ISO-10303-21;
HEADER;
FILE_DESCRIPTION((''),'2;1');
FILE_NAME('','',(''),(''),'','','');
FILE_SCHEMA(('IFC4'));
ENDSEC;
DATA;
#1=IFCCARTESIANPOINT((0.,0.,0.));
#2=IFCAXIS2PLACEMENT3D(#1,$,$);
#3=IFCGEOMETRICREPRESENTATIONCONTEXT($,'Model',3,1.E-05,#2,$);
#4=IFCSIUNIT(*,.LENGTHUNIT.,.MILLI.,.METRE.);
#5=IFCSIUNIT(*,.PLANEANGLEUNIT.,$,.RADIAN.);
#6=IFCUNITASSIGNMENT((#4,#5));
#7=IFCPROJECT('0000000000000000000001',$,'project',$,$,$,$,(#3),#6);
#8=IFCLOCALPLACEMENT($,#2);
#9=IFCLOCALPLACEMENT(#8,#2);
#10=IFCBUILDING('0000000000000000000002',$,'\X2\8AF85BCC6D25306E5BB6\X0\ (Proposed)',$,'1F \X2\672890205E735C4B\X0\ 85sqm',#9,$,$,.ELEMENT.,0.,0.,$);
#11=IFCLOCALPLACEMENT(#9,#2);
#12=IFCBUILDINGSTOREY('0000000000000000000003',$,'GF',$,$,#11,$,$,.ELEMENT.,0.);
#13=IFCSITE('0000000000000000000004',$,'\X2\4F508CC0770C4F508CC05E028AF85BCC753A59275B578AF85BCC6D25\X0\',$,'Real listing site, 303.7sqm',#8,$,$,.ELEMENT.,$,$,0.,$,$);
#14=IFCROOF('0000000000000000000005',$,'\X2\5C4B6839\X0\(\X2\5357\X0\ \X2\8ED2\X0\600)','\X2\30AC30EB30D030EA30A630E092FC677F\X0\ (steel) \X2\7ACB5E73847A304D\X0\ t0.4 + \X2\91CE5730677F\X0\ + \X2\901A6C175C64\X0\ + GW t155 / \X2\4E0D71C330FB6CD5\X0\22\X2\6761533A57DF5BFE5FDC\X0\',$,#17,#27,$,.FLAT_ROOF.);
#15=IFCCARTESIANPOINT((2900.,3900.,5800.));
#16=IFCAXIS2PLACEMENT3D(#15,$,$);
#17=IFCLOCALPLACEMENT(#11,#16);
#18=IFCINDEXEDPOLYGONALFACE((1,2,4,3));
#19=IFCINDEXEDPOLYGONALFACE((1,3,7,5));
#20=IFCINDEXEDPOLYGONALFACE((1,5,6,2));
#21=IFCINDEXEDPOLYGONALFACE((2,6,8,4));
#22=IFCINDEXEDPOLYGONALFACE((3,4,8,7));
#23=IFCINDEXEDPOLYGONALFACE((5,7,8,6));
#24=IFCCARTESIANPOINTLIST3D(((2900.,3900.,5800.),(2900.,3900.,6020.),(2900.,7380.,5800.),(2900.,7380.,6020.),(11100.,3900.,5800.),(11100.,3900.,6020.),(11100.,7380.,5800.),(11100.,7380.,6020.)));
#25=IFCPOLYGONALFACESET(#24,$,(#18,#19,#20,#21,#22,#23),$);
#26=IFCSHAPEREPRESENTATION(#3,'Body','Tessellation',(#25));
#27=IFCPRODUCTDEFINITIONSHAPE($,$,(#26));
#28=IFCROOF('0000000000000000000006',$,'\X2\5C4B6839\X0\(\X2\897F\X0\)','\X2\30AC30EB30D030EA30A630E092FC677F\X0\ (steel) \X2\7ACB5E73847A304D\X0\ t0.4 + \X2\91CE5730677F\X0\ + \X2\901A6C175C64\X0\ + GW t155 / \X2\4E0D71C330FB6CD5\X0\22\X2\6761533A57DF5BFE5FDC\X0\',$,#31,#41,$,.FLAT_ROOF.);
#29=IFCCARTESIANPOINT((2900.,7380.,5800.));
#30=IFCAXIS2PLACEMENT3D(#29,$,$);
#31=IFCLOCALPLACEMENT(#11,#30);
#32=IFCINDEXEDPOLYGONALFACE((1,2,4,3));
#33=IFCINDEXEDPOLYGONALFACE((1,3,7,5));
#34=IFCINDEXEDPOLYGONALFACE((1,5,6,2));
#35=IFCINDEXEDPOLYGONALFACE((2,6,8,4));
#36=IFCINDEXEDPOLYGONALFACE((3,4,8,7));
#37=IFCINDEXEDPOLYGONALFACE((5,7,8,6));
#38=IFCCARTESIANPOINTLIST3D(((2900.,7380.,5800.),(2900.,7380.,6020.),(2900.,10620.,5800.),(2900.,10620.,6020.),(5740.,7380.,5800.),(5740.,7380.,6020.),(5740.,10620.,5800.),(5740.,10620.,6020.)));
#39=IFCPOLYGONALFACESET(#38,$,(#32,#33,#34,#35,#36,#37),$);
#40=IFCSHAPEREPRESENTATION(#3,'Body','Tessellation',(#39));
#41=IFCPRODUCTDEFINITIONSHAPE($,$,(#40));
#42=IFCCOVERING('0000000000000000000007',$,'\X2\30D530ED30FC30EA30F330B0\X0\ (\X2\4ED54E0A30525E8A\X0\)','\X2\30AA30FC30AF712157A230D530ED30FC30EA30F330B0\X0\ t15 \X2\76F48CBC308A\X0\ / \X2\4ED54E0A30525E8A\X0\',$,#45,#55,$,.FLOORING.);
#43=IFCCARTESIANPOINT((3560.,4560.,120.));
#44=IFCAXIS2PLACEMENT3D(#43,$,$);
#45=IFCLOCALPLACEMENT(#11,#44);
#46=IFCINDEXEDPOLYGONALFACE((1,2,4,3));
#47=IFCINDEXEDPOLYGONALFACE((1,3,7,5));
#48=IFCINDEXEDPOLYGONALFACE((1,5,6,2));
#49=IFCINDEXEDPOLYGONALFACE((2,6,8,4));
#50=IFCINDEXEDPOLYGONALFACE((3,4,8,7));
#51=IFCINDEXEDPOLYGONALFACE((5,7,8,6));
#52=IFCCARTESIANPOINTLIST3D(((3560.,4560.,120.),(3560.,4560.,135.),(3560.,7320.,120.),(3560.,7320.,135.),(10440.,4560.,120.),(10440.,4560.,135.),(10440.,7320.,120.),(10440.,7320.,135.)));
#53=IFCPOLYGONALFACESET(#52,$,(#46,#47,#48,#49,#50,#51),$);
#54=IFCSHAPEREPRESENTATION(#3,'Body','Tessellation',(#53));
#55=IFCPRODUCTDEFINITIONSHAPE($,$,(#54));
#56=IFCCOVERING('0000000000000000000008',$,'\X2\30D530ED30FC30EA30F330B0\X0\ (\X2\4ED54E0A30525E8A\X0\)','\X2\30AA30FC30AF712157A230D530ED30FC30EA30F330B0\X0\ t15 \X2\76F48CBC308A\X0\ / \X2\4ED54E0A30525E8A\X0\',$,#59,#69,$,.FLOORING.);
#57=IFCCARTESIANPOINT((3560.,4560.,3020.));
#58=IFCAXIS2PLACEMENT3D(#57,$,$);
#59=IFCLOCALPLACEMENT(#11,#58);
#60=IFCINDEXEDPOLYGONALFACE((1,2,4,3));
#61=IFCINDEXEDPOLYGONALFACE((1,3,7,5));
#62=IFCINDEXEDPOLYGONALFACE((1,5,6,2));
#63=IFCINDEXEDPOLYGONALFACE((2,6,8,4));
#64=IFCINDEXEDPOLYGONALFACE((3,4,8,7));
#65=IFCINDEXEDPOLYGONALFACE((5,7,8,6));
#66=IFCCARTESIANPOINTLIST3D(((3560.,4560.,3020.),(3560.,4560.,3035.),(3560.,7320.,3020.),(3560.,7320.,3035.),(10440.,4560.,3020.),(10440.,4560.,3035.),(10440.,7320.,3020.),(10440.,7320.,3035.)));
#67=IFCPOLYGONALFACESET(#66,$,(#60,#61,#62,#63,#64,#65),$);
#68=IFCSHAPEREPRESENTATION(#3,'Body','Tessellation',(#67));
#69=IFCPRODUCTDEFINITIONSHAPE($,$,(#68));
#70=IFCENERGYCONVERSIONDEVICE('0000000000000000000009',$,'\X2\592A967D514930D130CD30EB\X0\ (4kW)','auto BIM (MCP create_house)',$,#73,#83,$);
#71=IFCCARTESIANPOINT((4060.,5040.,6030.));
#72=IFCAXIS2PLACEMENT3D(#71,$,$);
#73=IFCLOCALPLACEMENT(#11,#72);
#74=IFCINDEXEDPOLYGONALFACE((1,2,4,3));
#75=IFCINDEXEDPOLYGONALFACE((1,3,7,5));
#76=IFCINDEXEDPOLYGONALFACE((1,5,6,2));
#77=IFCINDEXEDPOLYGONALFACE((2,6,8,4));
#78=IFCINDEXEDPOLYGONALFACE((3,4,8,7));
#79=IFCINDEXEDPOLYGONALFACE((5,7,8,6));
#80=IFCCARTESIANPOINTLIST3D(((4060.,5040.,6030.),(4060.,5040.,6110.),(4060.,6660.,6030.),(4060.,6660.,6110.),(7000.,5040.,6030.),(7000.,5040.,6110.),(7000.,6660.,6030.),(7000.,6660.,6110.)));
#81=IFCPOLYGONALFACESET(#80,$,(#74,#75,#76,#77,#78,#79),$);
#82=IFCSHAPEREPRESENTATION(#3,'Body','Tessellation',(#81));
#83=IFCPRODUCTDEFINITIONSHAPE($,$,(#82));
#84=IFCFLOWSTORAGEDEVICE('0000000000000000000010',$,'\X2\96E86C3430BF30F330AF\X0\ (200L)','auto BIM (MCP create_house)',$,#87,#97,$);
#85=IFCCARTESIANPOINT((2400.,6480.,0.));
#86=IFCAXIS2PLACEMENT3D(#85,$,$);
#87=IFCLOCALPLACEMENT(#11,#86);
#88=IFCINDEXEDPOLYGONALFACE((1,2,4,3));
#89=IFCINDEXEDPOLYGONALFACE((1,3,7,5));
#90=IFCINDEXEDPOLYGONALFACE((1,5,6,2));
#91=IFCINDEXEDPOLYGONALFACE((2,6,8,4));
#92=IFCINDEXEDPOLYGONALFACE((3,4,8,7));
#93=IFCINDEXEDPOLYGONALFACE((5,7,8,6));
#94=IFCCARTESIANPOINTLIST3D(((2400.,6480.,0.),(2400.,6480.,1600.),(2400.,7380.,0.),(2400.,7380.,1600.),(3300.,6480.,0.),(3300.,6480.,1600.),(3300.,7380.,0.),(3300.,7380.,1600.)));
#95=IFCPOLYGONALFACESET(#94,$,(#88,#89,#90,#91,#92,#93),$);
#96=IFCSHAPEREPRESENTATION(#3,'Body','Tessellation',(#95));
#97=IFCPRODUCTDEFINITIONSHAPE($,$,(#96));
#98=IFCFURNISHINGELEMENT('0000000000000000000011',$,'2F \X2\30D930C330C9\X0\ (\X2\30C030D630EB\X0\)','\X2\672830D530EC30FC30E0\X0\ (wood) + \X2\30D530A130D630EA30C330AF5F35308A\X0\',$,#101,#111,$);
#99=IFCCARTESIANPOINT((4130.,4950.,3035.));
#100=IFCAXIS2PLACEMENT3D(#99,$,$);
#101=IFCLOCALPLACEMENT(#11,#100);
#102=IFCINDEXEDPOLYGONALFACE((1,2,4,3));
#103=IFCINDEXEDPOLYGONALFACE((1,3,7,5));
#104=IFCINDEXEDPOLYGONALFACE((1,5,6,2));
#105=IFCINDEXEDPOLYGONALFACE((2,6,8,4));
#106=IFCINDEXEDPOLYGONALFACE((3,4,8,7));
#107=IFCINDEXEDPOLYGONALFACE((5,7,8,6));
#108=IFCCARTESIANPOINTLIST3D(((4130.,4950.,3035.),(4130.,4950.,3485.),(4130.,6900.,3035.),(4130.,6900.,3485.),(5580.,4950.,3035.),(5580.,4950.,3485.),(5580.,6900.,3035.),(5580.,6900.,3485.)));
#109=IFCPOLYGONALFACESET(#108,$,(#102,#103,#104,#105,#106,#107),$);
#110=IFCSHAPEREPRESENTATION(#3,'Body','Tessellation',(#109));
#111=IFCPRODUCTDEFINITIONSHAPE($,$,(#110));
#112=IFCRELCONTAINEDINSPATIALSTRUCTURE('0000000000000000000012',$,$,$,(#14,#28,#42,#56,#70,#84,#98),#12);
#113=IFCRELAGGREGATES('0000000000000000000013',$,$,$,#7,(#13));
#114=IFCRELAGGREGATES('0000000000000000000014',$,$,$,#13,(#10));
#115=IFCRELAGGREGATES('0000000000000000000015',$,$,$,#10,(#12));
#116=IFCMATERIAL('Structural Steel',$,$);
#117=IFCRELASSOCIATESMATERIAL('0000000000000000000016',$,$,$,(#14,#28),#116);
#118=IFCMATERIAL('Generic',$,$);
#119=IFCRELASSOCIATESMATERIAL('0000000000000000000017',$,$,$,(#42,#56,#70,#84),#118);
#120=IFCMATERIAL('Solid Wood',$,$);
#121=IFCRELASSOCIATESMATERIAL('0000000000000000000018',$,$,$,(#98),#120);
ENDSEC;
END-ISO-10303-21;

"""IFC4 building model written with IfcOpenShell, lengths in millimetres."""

from ifc_helpers import new_model, si_unit, frame, frame_2d, origin, place, context, project, spatial, rectangle, extrude, material, element, save


model = new_model("IFC4")

# Units and contexts
model_context = context("Model", 3, precision=1e-05, world=origin())
ifc_project = project(units=[si_unit("LENGTHUNIT", "METRE", prefix="MILLI"), si_unit("PLANEANGLEUNIT", "RADIAN")], contexts=[model_context])

# Site, building, storey
site_placement = place(None, origin())
site = spatial("IfcSite", under=ifc_project, at=site_placement, Name="佐賀県佐賀市諸富町大字諸富津", ObjectType="Real listing site, 303.7sqm", CompositionType="ELEMENT", RefElevation=0.0)
building_placement = place(site_placement, origin())
building = spatial("IfcBuilding", under=site, at=building_placement, Name="諸富津の家 (Proposed)", ObjectType="1F 木造平屋 85sqm", CompositionType="ELEMENT", ElevationOfRefHeight=0.0, ElevationOfTerrain=0.0)
storey_placement = place(building_placement, origin())
storey = spatial("IfcBuildingStorey", under=building, at=storey_placement, Name="GF", CompositionType="ELEMENT", Elevation=0.0)

# Shared definitions
ifc_material_1 = material(Name="Solid Wood")
ifc_material_2 = material(Name="Generic")

# Roofs
ifc_material_3 = material(Name="Structural Steel")
roof_1_placement = place(storey_placement, frame((2900.0, 3900.0, 5800.0)))
element("IfcRoof", 1, at=roof_1_placement, inside=storey, material=ifc_material_3, Name="屋根(南 軒600)", Description="ガルバリウム鋼板 (steel) 立平葺き t0.4 + 野地板 + 通気層 + GW t155 / 不燃・法22条区域対応", PredefinedType="FLAT_ROOF", context=model_context, shape_type="SweptSolid", body=[
    extrude(rectangle(XDim=8200.0, YDim=3480.0, at=frame_2d((4100.0, 1740.0))), frame((2900.0, 3900.0, 5800.0)), (0.0, 0.0, 1.0), 220.0),
])
roof_2_placement = place(storey_placement, frame((2900.0, 7380.0, 5800.0)))
element("IfcRoof", 2, at=roof_2_placement, inside=storey, material=ifc_material_3, Name="屋根(西)", Description="ガルバリウム鋼板 (steel) 立平葺き t0.4 + 野地板 + 通気層 + GW t155 / 不燃・法22条区域対応", PredefinedType="FLAT_ROOF", context=model_context, shape_type="SweptSolid", body=[
    extrude(rectangle(XDim=2840.0, YDim=3240.0, at=frame_2d((1420.0, 1620.0))), frame((2900.0, 7380.0, 5800.0)), (0.0, 0.0, 1.0), 220.0),
])

# Coverings
covering_1_placement = place(storey_placement, frame((3560.0, 4560.0, 120.0)))
element("IfcCovering", 3, at=covering_1_placement, inside=storey, material=ifc_material_2, Name="フローリング (仕上げ床)", Description="オーク無垢フローリング t15 直貼り / 仕上げ床", PredefinedType="FLOORING", context=model_context, shape_type="SweptSolid", body=[
    extrude(rectangle(XDim=6880.0, YDim=2760.0, at=frame_2d((3440.0, 1380.0))), frame((3560.0, 4560.0, 120.0)), (0.0, 0.0, 1.0), 15.0),
])
covering_2_placement = place(storey_placement, frame((3560.0, 4560.0, 3020.0)))
element("IfcCovering", 4, at=covering_2_placement, inside=storey, material=ifc_material_2, Name="フローリング (仕上げ床)", Description="オーク無垢フローリング t15 直貼り / 仕上げ床", PredefinedType="FLOORING", context=model_context, shape_type="SweptSolid", body=[
    extrude(rectangle(XDim=6880.0, YDim=2760.0, at=frame_2d((3440.0, 1380.0))), frame((3560.0, 4560.0, 3020.0)), (0.0, 0.0, 1.0), 15.0),
])

# Energy conversion device
energy_conversion_device_placement = place(storey_placement, frame((4060.0, 5040.0, 6030.0)))
element("IfcEnergyConversionDevice", 5, at=energy_conversion_device_placement, inside=storey, material=ifc_material_2, Name="太陽光パネル (4kW)", Description="auto BIM (MCP create_house)", context=model_context, shape_type="SweptSolid", body=[
    extrude(rectangle(XDim=2940.0, YDim=1620.0, at=frame_2d((1470.0, 810.0))), frame((4060.0, 5040.0, 6030.0)), (0.0, 0.0, 1.0), 80.0),
])

# Flow storage device
flow_storage_device_placement = place(storey_placement, frame((2400.0, 6480.0, 0.0)))
element("IfcFlowStorageDevice", 6, at=flow_storage_device_placement, inside=storey, material=ifc_material_2, Name="雨水タンク (200L)", Description="auto BIM (MCP create_house)", context=model_context, shape_type="SweptSolid", body=[
    extrude(rectangle(XDim=900.0, YDim=900.0, at=frame_2d((450.0, 450.0))), frame((2400.0, 6480.0, 0.0)), (0.0, 0.0, 1.0), 1600.0),
])

# Furnishing element
furnishing_placement = place(storey_placement, frame((4130.0, 4950.0, 3035.0)))
element("IfcFurnishingElement", 7, at=furnishing_placement, inside=storey, material=ifc_material_1, Name="2F ベッド (ダブル)", Description="木フレーム (wood) + ファブリック張り", context=model_context, shape_type="SweptSolid", body=[
    extrude(rectangle(XDim=1450.0, YDim=1950.0, at=frame_2d((725.0, 975.0))), frame((4130.0, 4950.0, 3035.0)), (0.0, 0.0, 1.0), 450.0),
])

save(model, "model.ifc")
